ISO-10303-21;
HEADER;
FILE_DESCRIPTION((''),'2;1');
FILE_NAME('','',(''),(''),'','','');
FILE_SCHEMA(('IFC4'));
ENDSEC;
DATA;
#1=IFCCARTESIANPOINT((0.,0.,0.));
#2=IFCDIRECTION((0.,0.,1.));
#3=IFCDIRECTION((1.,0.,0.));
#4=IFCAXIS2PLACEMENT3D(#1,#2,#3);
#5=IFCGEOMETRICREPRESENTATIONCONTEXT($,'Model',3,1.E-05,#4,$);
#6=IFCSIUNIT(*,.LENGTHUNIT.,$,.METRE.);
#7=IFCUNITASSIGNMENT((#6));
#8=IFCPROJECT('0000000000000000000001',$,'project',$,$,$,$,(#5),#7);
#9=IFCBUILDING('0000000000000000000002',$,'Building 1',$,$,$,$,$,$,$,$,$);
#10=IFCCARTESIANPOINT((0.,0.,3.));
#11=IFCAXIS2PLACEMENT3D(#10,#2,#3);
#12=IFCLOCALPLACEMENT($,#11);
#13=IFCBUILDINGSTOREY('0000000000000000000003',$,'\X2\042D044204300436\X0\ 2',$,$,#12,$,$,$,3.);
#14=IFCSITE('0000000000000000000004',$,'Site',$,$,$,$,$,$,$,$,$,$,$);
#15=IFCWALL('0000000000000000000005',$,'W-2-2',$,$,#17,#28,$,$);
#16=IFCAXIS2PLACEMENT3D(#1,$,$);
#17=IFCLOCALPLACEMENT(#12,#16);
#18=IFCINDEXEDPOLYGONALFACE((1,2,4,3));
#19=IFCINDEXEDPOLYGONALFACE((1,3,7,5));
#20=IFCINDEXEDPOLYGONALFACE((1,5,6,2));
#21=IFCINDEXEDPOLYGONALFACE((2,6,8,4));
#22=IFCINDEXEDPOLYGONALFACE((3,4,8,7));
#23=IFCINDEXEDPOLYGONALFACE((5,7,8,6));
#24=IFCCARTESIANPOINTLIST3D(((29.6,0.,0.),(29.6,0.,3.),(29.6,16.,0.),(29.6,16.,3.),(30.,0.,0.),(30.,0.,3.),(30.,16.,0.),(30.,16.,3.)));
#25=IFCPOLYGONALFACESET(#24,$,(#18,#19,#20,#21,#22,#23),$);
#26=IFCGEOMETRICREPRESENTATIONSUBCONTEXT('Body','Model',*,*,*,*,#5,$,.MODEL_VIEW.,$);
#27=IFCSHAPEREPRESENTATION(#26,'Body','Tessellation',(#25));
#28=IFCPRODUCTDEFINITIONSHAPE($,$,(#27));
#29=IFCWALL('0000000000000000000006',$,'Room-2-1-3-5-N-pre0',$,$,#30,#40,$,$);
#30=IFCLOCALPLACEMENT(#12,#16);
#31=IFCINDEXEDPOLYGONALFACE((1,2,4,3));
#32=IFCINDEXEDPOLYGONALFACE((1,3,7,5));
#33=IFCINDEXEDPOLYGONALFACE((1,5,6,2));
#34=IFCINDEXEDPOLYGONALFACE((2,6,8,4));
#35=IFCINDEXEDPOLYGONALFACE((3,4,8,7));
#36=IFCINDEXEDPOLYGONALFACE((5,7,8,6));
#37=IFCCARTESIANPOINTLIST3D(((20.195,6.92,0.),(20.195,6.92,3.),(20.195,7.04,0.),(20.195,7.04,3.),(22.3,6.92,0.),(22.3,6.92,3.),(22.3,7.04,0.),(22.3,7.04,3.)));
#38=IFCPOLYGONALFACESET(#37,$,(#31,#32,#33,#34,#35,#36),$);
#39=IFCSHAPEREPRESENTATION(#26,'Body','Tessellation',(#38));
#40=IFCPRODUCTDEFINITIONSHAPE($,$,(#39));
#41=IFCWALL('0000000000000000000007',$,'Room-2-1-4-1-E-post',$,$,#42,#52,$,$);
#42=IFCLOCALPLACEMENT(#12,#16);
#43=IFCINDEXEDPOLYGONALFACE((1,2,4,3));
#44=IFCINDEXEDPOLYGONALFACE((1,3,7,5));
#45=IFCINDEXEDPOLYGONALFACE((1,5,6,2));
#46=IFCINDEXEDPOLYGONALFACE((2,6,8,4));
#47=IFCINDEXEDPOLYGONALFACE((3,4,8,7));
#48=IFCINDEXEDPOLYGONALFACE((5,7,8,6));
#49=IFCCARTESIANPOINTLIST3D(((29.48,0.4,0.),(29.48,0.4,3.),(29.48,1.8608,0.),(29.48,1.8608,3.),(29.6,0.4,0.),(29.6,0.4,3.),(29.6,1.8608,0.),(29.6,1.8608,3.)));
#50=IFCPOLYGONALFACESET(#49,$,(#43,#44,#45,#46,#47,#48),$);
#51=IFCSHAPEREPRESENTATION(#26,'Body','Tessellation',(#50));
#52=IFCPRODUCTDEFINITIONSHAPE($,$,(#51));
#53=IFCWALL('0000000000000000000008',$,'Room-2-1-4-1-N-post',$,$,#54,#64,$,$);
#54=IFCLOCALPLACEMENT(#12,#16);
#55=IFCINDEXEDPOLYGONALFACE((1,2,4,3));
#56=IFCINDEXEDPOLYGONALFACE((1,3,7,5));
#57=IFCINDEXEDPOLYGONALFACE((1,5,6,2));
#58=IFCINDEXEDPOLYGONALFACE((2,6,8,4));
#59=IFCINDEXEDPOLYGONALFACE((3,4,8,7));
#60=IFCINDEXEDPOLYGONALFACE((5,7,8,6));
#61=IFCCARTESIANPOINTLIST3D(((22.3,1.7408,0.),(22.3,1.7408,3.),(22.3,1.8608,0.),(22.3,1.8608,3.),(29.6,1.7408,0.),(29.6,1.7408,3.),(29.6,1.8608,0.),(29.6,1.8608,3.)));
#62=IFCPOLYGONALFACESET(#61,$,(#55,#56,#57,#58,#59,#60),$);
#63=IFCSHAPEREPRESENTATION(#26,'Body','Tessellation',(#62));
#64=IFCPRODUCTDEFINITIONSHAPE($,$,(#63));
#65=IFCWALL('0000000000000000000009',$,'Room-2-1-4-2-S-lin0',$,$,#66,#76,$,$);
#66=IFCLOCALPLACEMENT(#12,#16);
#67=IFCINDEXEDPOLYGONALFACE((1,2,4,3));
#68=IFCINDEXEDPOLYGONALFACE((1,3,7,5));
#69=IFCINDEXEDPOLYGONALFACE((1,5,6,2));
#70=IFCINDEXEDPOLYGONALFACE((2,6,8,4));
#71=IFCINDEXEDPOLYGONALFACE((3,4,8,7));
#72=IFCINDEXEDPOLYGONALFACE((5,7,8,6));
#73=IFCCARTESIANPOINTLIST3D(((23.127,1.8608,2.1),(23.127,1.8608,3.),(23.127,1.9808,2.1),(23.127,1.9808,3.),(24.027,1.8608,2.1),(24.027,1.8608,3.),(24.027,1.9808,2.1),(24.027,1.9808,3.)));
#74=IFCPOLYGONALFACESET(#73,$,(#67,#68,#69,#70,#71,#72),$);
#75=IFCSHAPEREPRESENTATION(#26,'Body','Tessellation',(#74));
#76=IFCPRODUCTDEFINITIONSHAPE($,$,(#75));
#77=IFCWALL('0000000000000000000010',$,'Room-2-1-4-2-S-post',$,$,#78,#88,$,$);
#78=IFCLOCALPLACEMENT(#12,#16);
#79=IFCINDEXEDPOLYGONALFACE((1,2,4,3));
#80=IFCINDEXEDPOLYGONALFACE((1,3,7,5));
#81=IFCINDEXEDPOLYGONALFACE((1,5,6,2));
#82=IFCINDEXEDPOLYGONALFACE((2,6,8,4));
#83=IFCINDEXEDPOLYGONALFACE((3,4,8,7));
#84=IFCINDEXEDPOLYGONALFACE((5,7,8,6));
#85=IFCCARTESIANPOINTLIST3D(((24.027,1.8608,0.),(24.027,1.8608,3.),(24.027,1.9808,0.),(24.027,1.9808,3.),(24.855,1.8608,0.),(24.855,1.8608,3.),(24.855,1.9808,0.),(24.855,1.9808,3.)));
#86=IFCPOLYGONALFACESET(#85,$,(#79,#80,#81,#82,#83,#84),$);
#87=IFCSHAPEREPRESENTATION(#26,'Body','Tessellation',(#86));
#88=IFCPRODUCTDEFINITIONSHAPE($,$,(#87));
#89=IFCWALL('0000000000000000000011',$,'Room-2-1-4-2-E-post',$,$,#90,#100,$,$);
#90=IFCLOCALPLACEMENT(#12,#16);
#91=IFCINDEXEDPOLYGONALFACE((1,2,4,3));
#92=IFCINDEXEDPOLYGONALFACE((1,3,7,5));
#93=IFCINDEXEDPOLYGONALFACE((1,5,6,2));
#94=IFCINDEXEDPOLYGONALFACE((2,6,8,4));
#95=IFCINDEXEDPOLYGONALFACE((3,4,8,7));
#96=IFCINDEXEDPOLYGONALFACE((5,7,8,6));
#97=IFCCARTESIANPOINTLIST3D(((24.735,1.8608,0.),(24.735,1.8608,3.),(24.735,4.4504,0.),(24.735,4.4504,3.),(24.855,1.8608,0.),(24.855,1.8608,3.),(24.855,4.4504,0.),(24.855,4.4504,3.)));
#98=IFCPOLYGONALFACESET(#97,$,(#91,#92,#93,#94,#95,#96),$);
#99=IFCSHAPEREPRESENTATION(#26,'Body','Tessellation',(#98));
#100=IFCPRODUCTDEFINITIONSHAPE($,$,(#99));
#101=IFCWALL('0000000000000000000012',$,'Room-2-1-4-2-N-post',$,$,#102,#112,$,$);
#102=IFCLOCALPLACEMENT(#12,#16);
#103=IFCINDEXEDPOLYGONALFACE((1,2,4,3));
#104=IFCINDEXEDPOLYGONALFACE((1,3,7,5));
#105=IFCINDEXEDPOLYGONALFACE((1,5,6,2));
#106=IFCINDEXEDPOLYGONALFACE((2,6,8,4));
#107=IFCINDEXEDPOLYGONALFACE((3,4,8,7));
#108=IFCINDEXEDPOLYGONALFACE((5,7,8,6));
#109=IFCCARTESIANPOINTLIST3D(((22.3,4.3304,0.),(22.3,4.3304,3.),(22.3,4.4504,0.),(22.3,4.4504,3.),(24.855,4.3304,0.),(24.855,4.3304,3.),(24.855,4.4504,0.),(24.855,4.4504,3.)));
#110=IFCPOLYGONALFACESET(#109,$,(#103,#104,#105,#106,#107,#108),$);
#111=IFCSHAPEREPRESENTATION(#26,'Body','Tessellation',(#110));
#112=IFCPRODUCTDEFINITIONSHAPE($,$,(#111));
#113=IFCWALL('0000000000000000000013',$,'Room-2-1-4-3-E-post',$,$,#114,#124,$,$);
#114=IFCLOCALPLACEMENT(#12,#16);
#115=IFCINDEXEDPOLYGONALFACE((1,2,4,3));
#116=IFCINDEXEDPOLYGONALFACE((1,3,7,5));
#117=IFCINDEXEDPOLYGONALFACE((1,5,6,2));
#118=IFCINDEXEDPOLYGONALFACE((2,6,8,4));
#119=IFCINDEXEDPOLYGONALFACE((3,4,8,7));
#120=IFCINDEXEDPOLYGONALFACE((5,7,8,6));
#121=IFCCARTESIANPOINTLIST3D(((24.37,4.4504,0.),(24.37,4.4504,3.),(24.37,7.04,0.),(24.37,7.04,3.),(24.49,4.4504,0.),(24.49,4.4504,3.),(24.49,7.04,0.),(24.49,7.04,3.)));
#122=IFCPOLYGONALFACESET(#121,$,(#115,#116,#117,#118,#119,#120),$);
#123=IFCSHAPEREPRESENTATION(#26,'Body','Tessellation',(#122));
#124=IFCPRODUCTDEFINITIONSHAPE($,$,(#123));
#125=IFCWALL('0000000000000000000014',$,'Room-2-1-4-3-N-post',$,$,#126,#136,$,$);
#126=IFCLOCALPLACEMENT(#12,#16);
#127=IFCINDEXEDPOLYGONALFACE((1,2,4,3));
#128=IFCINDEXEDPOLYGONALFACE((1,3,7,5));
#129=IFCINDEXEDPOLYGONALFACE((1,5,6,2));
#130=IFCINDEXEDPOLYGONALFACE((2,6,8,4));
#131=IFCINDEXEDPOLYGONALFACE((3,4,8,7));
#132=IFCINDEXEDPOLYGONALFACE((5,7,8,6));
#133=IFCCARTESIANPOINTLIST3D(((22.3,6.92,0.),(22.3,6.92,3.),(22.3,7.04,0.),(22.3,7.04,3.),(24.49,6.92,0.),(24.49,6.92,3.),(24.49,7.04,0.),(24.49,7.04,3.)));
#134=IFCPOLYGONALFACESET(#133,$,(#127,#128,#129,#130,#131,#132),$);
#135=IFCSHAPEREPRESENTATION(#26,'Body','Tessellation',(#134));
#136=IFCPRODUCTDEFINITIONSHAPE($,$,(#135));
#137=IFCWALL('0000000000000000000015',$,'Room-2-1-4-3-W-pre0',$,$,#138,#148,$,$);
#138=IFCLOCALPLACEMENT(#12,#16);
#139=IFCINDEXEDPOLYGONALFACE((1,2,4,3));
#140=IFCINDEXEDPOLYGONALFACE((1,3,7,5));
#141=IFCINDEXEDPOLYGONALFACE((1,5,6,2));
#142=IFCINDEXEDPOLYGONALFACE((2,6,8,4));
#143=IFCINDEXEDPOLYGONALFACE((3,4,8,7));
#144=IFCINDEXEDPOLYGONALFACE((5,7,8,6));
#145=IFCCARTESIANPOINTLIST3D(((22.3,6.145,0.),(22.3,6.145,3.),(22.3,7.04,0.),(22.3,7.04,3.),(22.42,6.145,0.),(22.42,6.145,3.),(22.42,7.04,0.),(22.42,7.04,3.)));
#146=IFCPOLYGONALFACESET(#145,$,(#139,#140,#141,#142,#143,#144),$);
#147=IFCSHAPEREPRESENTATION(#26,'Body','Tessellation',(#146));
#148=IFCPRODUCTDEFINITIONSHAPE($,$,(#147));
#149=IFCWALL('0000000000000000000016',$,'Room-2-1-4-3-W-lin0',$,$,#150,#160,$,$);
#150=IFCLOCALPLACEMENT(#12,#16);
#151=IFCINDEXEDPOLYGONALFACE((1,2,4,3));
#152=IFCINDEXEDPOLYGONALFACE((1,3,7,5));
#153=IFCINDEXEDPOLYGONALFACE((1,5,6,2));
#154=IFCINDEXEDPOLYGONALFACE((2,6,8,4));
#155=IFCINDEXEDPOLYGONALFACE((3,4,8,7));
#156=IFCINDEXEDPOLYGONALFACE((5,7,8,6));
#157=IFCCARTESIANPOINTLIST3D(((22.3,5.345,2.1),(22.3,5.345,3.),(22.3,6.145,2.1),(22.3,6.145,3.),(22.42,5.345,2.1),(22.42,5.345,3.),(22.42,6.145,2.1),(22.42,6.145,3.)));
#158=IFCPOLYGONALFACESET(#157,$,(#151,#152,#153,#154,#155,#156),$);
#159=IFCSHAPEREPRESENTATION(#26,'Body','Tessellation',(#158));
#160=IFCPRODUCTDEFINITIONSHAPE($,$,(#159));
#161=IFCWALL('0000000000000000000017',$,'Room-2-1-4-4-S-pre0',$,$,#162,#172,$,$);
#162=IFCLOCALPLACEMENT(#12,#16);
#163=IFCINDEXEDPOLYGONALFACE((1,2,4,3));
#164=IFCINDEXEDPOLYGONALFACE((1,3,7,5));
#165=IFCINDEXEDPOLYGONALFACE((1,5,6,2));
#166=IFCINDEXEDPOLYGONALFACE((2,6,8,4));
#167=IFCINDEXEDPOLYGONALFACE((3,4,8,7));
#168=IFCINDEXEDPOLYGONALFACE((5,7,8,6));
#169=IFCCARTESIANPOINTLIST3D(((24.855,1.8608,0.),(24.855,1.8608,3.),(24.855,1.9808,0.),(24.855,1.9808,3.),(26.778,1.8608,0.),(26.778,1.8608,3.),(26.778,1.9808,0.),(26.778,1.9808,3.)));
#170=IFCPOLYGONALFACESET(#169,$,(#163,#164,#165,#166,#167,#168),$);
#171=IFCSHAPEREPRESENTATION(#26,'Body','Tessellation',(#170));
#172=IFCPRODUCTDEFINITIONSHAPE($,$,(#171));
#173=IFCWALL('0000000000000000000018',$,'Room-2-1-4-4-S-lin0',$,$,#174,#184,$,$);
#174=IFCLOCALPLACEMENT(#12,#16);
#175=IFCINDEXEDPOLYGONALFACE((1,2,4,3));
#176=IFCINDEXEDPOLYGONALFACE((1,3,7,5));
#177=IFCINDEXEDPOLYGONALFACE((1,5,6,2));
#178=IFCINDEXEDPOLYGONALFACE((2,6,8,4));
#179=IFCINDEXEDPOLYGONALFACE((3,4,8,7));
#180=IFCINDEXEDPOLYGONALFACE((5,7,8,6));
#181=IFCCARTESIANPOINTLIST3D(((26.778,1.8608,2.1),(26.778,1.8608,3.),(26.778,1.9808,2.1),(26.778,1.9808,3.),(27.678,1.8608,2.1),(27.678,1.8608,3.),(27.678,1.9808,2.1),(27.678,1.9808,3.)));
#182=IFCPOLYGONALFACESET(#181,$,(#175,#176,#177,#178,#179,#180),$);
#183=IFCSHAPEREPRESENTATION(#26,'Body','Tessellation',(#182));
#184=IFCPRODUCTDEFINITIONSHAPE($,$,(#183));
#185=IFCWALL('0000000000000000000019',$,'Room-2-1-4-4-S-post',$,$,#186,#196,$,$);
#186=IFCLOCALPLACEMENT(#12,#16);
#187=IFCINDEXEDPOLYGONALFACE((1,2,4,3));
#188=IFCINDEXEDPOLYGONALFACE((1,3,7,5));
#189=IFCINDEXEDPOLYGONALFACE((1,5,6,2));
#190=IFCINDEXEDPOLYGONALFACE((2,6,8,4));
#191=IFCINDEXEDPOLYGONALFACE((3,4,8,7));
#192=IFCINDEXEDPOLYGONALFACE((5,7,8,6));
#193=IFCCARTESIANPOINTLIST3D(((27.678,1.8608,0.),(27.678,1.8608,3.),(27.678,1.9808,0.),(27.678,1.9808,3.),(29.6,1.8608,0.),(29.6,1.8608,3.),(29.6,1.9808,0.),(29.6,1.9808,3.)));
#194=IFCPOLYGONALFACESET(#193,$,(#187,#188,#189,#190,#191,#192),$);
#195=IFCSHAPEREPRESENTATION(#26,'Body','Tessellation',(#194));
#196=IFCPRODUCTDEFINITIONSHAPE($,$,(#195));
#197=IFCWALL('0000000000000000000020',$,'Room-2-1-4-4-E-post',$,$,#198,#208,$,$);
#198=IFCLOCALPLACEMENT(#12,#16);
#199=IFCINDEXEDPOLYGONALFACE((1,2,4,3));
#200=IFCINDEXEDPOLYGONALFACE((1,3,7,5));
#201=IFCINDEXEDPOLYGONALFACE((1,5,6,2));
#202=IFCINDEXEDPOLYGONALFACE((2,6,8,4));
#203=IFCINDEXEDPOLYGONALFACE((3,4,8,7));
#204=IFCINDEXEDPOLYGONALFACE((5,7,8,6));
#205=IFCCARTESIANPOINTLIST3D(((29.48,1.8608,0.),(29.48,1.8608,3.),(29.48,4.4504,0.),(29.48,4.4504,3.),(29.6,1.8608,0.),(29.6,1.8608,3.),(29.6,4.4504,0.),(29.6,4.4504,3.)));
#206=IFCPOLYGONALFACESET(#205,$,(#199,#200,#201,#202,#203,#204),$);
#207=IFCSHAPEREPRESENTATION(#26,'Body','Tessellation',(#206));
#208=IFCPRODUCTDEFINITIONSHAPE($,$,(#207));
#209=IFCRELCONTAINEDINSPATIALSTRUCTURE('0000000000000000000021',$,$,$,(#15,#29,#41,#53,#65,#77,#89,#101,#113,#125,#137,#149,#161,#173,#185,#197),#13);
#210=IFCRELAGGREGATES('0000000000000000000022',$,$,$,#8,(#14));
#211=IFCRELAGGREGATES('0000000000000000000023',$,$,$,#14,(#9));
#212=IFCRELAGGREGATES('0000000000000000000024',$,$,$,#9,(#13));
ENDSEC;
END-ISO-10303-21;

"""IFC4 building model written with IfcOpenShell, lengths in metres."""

from ifc_helpers import new_model, si_unit, frame, origin_with_axes, place, context, subcontext, project, spatial, indexed_curve, outline, extrude, element, save


model = new_model("IFC4")

# Units and contexts
model_context = context("Model", 3, precision=1e-05, world=origin_with_axes())
body_context = subcontext(model_context, "Body", "Model", "MODEL_VIEW")
ifc_project = project(units=[si_unit("LENGTHUNIT", "METRE")], contexts=[model_context])

# Site, building, storey
site = spatial("IfcSite", under=ifc_project, Name="Site")
building = spatial("IfcBuilding", under=site, Name="Building 1")
storey_placement = place(None, frame((0.0, 0.0, 3.0), z_axis=(0.0, 0.0, 1.0), x_axis=(1.0, 0.0, 0.0)))
storey = spatial("IfcBuildingStorey", under=building, at=storey_placement, Name="Этаж 2", Elevation=3.0)

# Walls
wall_1_placement = place(storey_placement, frame((30.0, 0.0, 0.0), z_axis=(0.0, 0.0, 1.0), x_axis=(0.0, 1.0, 0.0)))
element("IfcWall", 1, at=wall_1_placement, inside=storey, Name="W-2-2", context=body_context, shape_type="SweptSolid", body=[
    extrude(outline(indexed_curve([(0.0, 0.0), (0.0, 0.4), (16.0, 0.4), (16.0, 0.0), (0.0, 0.0)], self_intersect=False)), origin_with_axes(), (0.0, 0.0, 1.0), 3.0),
])
wall_2_placement = place(storey_placement, frame((22.3, 7.04, 0.0), z_axis=(0.0, 0.0, 1.0), x_axis=(-1.0, 0.0, 0.0)))
element("IfcWall", 2, at=wall_2_placement, inside=storey, Name="Room-2-1-3-5-N-pre0", context=body_context, shape_type="SweptSolid", body=[
    extrude(outline(indexed_curve([(0.0, 0.0), (0.0, 0.12), (2.105, 0.12), (2.105, 0.0), (0.0, 0.0)], self_intersect=False)), origin_with_axes(), (0.0, 0.0, 1.0), 3.0),
])
wall_3_placement = place(storey_placement, frame((29.6, 0.4, 0.0), z_axis=(0.0, 0.0, 1.0), x_axis=(0.0, 1.0, 0.0)))
element("IfcWall", 3, at=wall_3_placement, inside=storey, Name="Room-2-1-4-1-E-post", context=body_context, shape_type="SweptSolid", body=[
    extrude(outline(indexed_curve([(0.0, 0.0), (0.0, 0.12), (1.4608, 0.12), (1.4608, 0.0), (0.0, 0.0)], self_intersect=False)), origin_with_axes(), (0.0, 0.0, 1.0), 3.0),
])
wall_4_placement = place(storey_placement, frame((29.6, 1.8608, 0.0), z_axis=(0.0, 0.0, 1.0), x_axis=(-1.0, 0.0, 0.0)))
element("IfcWall", 4, at=wall_4_placement, inside=storey, Name="Room-2-1-4-1-N-post", context=body_context, shape_type="SweptSolid", body=[
    extrude(outline(indexed_curve([(0.0, 0.0), (0.0, 0.12), (7.3, 0.12), (7.3, 0.0), (0.0, 0.0)], self_intersect=False)), origin_with_axes(), (0.0, 0.0, 1.0), 3.0),
])
wall_5_placement = place(storey_placement, frame((23.127, 1.8608, 2.1), z_axis=(0.0, 0.0, 1.0), x_axis=(1.0, 0.0, 0.0)))
element("IfcWall", 5, at=wall_5_placement, inside=storey, Name="Room-2-1-4-2-S-lin0", context=body_context, shape_type="SweptSolid", body=[
    extrude(outline(indexed_curve([(0.0, 0.0), (0.0, 0.12), (0.9, 0.12), (0.9, 0.0), (0.0, 0.0)], self_intersect=False)), origin_with_axes(), (0.0, 0.0, 1.0), 0.9),
])
wall_6_placement = place(storey_placement, frame((24.027, 1.8608, 0.0), z_axis=(0.0, 0.0, 1.0), x_axis=(1.0, 0.0, 0.0)))
element("IfcWall", 6, at=wall_6_placement, inside=storey, Name="Room-2-1-4-2-S-post", context=body_context, shape_type="SweptSolid", body=[
    extrude(outline(indexed_curve([(0.0, 0.0), (0.0, 0.12), (0.828, 0.12), (0.828, 0.0), (0.0, 0.0)], self_intersect=False)), origin_with_axes(), (0.0, 0.0, 1.0), 3.0),
])
wall_7_placement = place(storey_placement, frame((24.855, 1.8608, 0.0), z_axis=(0.0, 0.0, 1.0), x_axis=(0.0, 1.0, 0.0)))
element("IfcWall", 7, at=wall_7_placement, inside=storey, Name="Room-2-1-4-2-E-post", context=body_context, shape_type="SweptSolid", body=[
    extrude(outline(indexed_curve([(0.0, 0.0), (0.0, 0.12), (2.5896, 0.12), (2.5896, 0.0), (0.0, 0.0)], self_intersect=False)), origin_with_axes(), (0.0, 0.0, 1.0), 3.0),
])
wall_8_placement = place(storey_placement, frame((24.855, 4.4504, 0.0), z_axis=(0.0, 0.0, 1.0), x_axis=(-1.0, 0.0, 0.0)))
element("IfcWall", 8, at=wall_8_placement, inside=storey, Name="Room-2-1-4-2-N-post", context=body_context, shape_type="SweptSolid", body=[
    extrude(outline(indexed_curve([(0.0, 0.0), (0.0, 0.12), (2.555, 0.12), (2.555, 0.0), (0.0, 0.0)], self_intersect=False)), origin_with_axes(), (0.0, 0.0, 1.0), 3.0),
])
wall_9_placement = place(storey_placement, frame((24.49, 4.4504, 0.0), z_axis=(0.0, 0.0, 1.0), x_axis=(0.0, 1.0, 0.0)))
element("IfcWall", 9, at=wall_9_placement, inside=storey, Name="Room-2-1-4-3-E-post", context=body_context, shape_type="SweptSolid", body=[
    extrude(outline(indexed_curve([(0.0, 0.0), (0.0, 0.12), (2.5896, 0.12), (2.5896, 0.0), (0.0, 0.0)], self_intersect=False)), origin_with_axes(), (0.0, 0.0, 1.0), 3.0),
])
wall_10_placement = place(storey_placement, frame((24.49, 7.04, 0.0), z_axis=(0.0, 0.0, 1.0), x_axis=(-1.0, 0.0, 0.0)))
element("IfcWall", 10, at=wall_10_placement, inside=storey, Name="Room-2-1-4-3-N-post", context=body_context, shape_type="SweptSolid", body=[
    extrude(outline(indexed_curve([(0.0, 0.0), (0.0, 0.12), (2.19, 0.12), (2.19, 0.0), (0.0, 0.0)], self_intersect=False)), origin_with_axes(), (0.0, 0.0, 1.0), 3.0),
])
wall_11_placement = place(storey_placement, frame((22.3, 7.04, 0.0), z_axis=(0.0, 0.0, 1.0), x_axis=(0.0, -1.0, 0.0)))
element("IfcWall", 11, at=wall_11_placement, inside=storey, Name="Room-2-1-4-3-W-pre0", context=body_context, shape_type="SweptSolid", body=[
    extrude(outline(indexed_curve([(0.0, 0.0), (0.0, 0.12), (0.895, 0.12), (0.895, 0.0), (0.0, 0.0)], self_intersect=False)), origin_with_axes(), (0.0, 0.0, 1.0), 3.0),
])
wall_12_placement = place(storey_placement, frame((22.3, 6.145, 2.1), z_axis=(0.0, 0.0, 1.0), x_axis=(0.0, -1.0, 0.0)))
element("IfcWall", 12, at=wall_12_placement, inside=storey, Name="Room-2-1-4-3-W-lin0", context=body_context, shape_type="SweptSolid", body=[
    extrude(outline(indexed_curve([(0.0, 0.0), (0.0, 0.12), (0.8, 0.12), (0.8, 0.0), (0.0, 0.0)], self_intersect=False)), origin_with_axes(), (0.0, 0.0, 1.0), 0.9),
])
wall_13_placement = place(storey_placement, frame((24.855, 1.8608, 0.0), z_axis=(0.0, 0.0, 1.0), x_axis=(1.0, 0.0, 0.0)))
element("IfcWall", 13, at=wall_13_placement, inside=storey, Name="Room-2-1-4-4-S-pre0", context=body_context, shape_type="SweptSolid", body=[
    extrude(outline(indexed_curve([(0.0, 0.0), (0.0, 0.12), (1.923, 0.12), (1.923, 0.0), (0.0, 0.0)], self_intersect=False)), origin_with_axes(), (0.0, 0.0, 1.0), 3.0),
])
wall_14_placement = place(storey_placement, frame((26.778, 1.8608, 2.1), z_axis=(0.0, 0.0, 1.0), x_axis=(1.0, 0.0, 0.0)))
element("IfcWall", 14, at=wall_14_placement, inside=storey, Name="Room-2-1-4-4-S-lin0", context=body_context, shape_type="SweptSolid", body=[
    extrude(outline(indexed_curve([(0.0, 0.0), (0.0, 0.12), (0.9, 0.12), (0.9, 0.0), (0.0, 0.0)], self_intersect=False)), origin_with_axes(), (0.0, 0.0, 1.0), 0.9),
])
wall_15_placement = place(storey_placement, frame((27.678, 1.8608, 0.0), z_axis=(0.0, 0.0, 1.0), x_axis=(1.0, 0.0, 0.0)))
element("IfcWall", 15, at=wall_15_placement, inside=storey, Name="Room-2-1-4-4-S-post", context=body_context, shape_type="SweptSolid", body=[
    extrude(outline(indexed_curve([(0.0, 0.0), (0.0, 0.12), (1.922, 0.12), (1.922, 0.0), (0.0, 0.0)], self_intersect=False)), origin_with_axes(), (0.0, 0.0, 1.0), 3.0),
])
wall_16_placement = place(storey_placement, frame((29.6, 1.8608, 0.0), z_axis=(0.0, 0.0, 1.0), x_axis=(0.0, 1.0, 0.0)))
element("IfcWall", 16, at=wall_16_placement, inside=storey, Name="Room-2-1-4-4-E-post", context=body_context, shape_type="SweptSolid", body=[
    extrude(outline(indexed_curve([(0.0, 0.0), (0.0, 0.12), (2.5896, 0.12), (2.5896, 0.0), (0.0, 0.0)], self_intersect=False)), origin_with_axes(), (0.0, 0.0, 1.0), 3.0),
])

save(model, "model.ifc")
